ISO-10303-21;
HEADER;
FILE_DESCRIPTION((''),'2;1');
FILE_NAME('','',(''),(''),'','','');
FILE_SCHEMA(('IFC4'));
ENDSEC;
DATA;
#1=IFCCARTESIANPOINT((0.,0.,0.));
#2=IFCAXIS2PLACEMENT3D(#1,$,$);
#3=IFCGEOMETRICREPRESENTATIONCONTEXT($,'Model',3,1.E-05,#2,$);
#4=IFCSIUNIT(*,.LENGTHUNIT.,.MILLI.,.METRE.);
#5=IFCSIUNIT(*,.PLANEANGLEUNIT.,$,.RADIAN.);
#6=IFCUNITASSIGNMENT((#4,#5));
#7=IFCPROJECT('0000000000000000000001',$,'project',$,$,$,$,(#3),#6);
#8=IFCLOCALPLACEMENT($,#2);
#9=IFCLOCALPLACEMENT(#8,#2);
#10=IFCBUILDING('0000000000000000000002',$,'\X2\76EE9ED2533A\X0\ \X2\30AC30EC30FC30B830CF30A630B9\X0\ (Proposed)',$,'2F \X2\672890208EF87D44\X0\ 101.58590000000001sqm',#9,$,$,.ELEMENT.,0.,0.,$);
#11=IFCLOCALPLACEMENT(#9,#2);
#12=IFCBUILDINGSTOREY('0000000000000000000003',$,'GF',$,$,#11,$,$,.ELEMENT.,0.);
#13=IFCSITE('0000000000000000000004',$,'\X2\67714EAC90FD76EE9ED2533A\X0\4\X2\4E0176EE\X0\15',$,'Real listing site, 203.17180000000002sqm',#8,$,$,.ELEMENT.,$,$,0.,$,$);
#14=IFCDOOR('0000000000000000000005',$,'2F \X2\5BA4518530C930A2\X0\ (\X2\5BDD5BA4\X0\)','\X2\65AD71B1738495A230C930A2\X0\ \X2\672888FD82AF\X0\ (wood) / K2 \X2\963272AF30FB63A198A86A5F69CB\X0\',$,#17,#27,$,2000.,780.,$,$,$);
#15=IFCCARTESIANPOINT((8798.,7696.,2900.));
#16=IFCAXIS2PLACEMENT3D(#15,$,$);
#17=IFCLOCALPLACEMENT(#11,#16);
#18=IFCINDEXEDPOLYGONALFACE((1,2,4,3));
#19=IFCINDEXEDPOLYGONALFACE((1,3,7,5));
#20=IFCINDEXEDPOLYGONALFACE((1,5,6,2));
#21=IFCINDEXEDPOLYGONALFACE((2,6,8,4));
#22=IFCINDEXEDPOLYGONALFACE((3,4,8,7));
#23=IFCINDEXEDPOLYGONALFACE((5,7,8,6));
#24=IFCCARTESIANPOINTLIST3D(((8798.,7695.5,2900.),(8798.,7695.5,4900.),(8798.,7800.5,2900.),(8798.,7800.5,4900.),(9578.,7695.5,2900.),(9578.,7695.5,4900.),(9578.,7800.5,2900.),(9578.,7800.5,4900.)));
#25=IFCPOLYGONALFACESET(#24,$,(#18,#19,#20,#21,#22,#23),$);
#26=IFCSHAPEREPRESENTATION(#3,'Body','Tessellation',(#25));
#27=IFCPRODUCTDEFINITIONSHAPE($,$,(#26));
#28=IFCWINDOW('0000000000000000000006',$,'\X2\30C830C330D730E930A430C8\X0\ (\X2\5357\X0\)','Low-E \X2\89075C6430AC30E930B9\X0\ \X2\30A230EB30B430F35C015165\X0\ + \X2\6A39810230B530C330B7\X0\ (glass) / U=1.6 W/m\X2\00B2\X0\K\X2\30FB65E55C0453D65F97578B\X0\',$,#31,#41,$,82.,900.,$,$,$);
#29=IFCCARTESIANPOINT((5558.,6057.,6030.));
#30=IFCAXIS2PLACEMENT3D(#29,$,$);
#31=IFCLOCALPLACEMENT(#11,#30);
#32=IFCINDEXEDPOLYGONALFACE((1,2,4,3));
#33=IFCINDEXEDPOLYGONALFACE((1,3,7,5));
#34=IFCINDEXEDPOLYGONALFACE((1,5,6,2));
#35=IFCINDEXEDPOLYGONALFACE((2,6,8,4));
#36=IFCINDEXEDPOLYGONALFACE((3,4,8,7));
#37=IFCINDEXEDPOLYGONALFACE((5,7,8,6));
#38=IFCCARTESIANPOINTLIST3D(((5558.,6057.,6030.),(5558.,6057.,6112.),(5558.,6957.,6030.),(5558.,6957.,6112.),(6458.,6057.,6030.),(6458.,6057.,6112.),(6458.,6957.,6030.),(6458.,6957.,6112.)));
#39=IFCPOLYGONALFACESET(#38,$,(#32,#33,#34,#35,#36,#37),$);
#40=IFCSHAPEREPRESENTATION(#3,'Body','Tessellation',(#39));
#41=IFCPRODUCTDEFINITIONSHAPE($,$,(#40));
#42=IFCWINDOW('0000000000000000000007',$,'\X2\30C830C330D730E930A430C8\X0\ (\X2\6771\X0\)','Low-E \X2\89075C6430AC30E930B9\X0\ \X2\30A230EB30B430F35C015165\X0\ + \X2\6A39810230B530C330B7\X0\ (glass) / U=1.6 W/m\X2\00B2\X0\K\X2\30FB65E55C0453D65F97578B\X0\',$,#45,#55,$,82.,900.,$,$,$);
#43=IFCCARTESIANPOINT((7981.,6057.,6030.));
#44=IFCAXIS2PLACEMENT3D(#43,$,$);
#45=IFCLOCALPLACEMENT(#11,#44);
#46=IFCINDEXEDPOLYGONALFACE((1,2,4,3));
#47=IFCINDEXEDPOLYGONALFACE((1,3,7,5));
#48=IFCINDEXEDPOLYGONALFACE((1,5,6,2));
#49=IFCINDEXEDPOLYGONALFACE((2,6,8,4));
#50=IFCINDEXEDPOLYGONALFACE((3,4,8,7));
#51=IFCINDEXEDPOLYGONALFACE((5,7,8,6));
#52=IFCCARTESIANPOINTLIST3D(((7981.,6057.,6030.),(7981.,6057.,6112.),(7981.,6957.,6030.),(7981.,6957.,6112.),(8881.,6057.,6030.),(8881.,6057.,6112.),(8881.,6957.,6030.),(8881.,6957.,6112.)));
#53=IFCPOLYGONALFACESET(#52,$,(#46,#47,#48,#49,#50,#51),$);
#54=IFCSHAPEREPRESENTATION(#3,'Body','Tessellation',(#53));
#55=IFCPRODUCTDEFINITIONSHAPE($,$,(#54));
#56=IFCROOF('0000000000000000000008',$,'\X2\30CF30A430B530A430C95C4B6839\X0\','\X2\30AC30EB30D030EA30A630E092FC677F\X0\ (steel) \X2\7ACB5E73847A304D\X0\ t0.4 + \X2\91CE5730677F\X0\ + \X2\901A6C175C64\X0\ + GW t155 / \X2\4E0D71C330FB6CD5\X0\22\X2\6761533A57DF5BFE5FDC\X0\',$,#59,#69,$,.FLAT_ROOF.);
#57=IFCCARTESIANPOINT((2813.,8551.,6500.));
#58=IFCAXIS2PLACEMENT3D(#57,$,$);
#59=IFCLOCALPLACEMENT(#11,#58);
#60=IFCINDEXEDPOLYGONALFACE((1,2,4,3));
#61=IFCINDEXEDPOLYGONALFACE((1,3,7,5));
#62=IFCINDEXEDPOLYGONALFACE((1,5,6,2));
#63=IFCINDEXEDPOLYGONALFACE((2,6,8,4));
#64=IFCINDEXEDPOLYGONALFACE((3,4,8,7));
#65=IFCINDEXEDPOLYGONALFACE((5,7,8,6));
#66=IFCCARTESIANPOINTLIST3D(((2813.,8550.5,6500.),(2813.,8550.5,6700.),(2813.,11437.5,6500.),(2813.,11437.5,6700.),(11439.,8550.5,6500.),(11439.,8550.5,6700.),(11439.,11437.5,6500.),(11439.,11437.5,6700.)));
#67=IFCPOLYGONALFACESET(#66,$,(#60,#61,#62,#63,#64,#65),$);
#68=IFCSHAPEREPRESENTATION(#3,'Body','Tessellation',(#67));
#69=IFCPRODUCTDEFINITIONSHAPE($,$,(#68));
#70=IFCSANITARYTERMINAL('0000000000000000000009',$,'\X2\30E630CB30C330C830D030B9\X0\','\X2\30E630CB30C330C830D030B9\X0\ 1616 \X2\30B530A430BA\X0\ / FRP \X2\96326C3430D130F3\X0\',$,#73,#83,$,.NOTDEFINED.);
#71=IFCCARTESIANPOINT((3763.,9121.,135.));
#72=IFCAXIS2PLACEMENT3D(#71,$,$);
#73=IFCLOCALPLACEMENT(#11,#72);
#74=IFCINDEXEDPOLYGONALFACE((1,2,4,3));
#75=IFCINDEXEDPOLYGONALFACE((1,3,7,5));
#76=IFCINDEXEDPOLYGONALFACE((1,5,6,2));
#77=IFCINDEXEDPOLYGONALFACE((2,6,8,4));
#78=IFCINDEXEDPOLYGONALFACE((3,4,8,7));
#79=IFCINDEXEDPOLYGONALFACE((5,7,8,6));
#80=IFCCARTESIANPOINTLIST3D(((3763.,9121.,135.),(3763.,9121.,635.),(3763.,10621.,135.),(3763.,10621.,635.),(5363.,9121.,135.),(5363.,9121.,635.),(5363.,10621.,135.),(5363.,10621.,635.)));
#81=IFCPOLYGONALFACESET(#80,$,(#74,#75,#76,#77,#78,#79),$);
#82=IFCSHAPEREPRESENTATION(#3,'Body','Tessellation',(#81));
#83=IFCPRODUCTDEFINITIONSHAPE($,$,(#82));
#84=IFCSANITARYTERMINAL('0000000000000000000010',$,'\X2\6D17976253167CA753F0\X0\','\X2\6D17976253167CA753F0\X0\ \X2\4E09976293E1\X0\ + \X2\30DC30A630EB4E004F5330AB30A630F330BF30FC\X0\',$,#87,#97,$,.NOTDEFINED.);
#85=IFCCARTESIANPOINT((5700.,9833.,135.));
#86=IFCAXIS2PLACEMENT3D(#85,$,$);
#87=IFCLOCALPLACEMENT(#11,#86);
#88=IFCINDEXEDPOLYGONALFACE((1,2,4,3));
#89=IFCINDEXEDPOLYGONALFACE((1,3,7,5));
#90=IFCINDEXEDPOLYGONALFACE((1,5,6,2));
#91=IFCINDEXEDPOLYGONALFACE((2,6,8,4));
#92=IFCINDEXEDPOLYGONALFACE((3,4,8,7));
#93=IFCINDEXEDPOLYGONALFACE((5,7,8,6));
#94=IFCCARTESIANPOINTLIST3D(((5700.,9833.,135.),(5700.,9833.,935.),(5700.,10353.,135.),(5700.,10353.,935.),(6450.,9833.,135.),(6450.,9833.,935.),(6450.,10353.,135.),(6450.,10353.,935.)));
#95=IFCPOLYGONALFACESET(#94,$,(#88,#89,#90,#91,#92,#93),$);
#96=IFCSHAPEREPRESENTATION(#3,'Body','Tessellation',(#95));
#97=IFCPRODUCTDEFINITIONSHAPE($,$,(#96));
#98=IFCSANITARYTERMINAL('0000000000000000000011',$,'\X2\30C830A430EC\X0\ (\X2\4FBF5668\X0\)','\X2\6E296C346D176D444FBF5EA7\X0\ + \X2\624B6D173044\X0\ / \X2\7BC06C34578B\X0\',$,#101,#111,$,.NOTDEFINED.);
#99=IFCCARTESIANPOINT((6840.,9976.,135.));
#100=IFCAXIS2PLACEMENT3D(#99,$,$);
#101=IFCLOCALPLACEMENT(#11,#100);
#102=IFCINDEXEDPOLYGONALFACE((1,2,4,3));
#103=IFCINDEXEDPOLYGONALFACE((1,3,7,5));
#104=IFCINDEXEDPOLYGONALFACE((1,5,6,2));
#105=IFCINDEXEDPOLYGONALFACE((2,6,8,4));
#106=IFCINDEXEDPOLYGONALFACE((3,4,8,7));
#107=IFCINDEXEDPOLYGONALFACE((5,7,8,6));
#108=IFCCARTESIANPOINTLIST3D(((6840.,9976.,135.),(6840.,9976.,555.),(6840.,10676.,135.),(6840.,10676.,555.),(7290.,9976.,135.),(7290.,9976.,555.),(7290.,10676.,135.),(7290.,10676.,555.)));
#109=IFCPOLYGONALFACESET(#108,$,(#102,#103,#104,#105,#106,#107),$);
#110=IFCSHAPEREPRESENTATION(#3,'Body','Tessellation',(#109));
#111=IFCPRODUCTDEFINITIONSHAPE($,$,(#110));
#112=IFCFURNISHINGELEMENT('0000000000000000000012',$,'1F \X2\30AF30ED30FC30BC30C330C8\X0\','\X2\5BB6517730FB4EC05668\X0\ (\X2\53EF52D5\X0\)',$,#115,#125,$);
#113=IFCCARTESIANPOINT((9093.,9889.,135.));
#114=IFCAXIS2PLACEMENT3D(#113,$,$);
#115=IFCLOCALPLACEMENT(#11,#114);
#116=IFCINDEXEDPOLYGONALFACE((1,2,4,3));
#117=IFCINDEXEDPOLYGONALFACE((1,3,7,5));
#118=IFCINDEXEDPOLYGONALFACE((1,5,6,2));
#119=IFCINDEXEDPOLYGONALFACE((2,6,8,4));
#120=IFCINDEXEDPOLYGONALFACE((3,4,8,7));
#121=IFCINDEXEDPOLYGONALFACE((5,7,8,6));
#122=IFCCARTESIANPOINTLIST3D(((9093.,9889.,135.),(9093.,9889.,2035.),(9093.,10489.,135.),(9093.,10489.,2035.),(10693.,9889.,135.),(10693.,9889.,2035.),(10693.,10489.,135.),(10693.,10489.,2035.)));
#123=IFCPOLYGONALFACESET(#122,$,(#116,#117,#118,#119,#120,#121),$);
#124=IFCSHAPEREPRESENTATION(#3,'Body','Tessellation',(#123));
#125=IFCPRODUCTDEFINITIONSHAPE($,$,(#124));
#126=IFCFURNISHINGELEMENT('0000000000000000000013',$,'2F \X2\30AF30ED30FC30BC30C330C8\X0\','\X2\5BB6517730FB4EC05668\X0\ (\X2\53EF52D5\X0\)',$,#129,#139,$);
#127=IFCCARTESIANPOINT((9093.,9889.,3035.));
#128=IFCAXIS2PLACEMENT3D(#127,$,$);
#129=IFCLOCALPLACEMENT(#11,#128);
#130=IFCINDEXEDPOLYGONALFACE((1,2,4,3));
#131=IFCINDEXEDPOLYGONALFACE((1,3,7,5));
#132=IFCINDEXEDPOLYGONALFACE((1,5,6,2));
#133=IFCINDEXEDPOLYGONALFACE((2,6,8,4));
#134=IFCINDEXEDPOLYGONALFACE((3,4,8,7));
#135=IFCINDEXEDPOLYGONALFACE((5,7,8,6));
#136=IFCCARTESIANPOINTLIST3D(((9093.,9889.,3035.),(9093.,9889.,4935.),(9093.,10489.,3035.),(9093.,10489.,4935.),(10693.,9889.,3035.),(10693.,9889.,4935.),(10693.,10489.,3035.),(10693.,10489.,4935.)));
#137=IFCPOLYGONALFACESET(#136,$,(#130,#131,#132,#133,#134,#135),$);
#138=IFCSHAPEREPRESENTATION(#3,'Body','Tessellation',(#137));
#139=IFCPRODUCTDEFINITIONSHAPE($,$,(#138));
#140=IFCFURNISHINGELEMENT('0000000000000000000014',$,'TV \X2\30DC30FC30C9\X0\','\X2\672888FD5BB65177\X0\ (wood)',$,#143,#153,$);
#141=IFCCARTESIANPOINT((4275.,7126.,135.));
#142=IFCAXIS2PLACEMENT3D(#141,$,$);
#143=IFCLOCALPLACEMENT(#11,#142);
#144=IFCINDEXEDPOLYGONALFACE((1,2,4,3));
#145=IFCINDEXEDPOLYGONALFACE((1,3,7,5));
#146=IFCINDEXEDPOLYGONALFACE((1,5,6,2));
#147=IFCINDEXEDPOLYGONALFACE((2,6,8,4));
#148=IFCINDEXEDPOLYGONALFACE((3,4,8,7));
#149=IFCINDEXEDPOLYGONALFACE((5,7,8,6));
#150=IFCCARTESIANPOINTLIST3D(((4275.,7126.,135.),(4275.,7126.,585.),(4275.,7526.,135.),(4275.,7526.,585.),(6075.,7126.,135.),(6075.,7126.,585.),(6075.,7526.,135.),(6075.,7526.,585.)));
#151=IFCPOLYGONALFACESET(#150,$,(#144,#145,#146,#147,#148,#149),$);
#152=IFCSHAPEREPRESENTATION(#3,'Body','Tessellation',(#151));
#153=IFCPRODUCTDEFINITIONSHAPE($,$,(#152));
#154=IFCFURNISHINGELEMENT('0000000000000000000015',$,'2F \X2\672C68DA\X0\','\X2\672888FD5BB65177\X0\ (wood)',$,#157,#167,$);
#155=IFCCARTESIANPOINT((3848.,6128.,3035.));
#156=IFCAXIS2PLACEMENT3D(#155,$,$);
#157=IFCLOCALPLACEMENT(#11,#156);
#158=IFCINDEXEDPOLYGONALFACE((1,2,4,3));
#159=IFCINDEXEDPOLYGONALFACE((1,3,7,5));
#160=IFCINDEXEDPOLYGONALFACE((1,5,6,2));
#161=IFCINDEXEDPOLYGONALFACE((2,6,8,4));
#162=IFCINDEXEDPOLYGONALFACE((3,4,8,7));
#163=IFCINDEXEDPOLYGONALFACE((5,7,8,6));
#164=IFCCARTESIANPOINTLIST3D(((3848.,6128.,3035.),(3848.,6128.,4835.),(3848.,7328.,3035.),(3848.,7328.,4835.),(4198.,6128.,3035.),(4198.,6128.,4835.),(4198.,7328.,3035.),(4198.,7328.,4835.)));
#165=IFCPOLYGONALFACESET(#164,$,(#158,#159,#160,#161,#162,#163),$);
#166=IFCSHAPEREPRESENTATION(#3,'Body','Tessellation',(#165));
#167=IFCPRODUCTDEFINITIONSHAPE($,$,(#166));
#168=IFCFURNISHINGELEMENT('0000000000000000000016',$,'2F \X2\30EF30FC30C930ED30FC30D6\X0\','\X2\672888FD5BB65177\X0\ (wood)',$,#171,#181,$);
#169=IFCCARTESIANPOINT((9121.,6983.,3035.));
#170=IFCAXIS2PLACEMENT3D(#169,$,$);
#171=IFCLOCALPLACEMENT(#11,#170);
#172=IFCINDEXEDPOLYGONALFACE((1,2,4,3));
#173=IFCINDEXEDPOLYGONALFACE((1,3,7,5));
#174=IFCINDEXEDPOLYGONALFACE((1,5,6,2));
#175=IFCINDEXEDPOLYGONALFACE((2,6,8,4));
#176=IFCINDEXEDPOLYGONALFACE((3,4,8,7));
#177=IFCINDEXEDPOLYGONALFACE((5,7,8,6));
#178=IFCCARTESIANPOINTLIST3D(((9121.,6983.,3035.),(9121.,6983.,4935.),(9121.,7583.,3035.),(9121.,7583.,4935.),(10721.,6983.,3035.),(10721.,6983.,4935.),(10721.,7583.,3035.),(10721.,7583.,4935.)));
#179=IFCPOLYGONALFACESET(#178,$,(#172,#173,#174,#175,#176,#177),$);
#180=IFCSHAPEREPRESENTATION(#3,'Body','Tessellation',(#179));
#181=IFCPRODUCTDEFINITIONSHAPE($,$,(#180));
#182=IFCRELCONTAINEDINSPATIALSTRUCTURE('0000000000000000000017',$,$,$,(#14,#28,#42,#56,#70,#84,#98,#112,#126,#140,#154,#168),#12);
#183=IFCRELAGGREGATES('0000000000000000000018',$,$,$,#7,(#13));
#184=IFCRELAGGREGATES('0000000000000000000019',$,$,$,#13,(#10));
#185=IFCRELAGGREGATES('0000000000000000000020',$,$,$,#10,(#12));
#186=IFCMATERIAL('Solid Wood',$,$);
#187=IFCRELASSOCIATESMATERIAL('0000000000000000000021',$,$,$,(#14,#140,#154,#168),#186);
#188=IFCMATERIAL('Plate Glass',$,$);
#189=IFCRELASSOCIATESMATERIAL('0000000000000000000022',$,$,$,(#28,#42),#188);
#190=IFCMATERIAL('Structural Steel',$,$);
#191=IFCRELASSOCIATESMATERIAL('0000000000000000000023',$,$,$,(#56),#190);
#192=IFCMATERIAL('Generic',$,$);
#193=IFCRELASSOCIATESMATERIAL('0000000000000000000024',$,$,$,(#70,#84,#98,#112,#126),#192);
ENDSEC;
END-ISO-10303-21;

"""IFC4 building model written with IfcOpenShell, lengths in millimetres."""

from ifc_helpers import new_model, si_unit, frame, frame_2d, origin, place, context, project, spatial, rectangle, extrude, material, element, save


model = new_model("IFC4")

# Units and contexts
model_context = context("Model", 3, precision=1e-05, world=origin())
ifc_project = project(units=[si_unit("LENGTHUNIT", "METRE", prefix="MILLI"), si_unit("PLANEANGLEUNIT", "RADIAN")], contexts=[model_context])

# Site, building, storey
site_placement = place(None, origin())
site = spatial("IfcSite", under=ifc_project, at=site_placement, Name="東京都目黒区4丁目15", ObjectType="Real listing site, 203.17180000000002sqm", CompositionType="ELEMENT", RefElevation=0.0)
building_placement = place(site_placement, origin())
building = spatial("IfcBuilding", under=site, at=building_placement, Name="目黒区 ガレージハウス (Proposed)", ObjectType="2F 木造軸組 101.58590000000001sqm", CompositionType="ELEMENT", ElevationOfRefHeight=0.0, ElevationOfTerrain=0.0)
storey_placement = place(building_placement, origin())
storey = spatial("IfcBuildingStorey", under=building, at=storey_placement, Name="GF", CompositionType="ELEMENT", Elevation=0.0)

# Shared definitions
ifc_material_1 = material(Name="Solid Wood")
ifc_material_2 = material(Name="Plate Glass")

# Door
door_1_placement = place(storey_placement, frame((8798.0, 7696.0, 2900.0)))
element("IfcDoor", 1, at=door_1_placement, inside=storey, material=ifc_material_1, Name="2F 室内ドア (寝室)", Description="断熱玄関ドア 木製芯 (wood) / K2 防犯・採風機構", OverallHeight=2000.0, OverallWidth=780.0, context=model_context, shape_type="SweptSolid", body=[
    extrude(rectangle(XDim=780.0, YDim=105.0, at=frame_2d((390.0, 52.0))), frame((8798.0, 7696.0, 2900.0)), (0.0, 0.0, 1.0), 2000.0),
])

# Windows
window_1_placement = place(storey_placement, frame((5558.0, 6057.0, 6030.0)))
element("IfcWindow", 2, at=window_1_placement, inside=storey, material=ifc_material_2, Name="トップライト (南)", Description="Low-E 複層ガラス アルゴン封入 + 樹脂サッシ (glass) / U=1.6 W/m²K・日射取得型", OverallHeight=82.0, OverallWidth=900.0, context=model_context, shape_type="SweptSolid", body=[
    extrude(rectangle(XDim=900.0, YDim=900.0, at=frame_2d((450.0, 450.0))), frame((5558.0, 6057.0, 6030.0)), (0.0, 0.0, 1.0), 82.0),
])
window_2_placement = place(storey_placement, frame((7981.0, 6057.0, 6030.0)))
element("IfcWindow", 3, at=window_2_placement, inside=storey, material=ifc_material_2, Name="トップライト (東)", Description="Low-E 複層ガラス アルゴン封入 + 樹脂サッシ (glass) / U=1.6 W/m²K・日射取得型", OverallHeight=82.0, OverallWidth=900.0, context=model_context, shape_type="SweptSolid", body=[
    extrude(rectangle(XDim=900.0, YDim=900.0, at=frame_2d((450.0, 450.0))), frame((7981.0, 6057.0, 6030.0)), (0.0, 0.0, 1.0), 82.0),
])

# Roof
ifc_material_3 = material(Name="Structural Steel")
roof_placement = place(storey_placement, frame((2813.0, 8551.0, 6500.0)))
element("IfcRoof", 4, at=roof_placement, inside=storey, material=ifc_material_3, Name="ハイサイド屋根", Description="ガルバリウム鋼板 (steel) 立平葺き t0.4 + 野地板 + 通気層 + GW t155 / 不燃・法22条区域対応", PredefinedType="FLAT_ROOF", context=model_context, shape_type="SweptSolid", body=[
    extrude(rectangle(XDim=8626.0, YDim=2887.0, at=frame_2d((4313.0, 1443.0))), frame((2813.0, 8551.0, 6500.0)), (0.0, 0.0, 1.0), 200.0),
])

# Sanitary terminals
ifc_material_4 = material(Name="Generic")
sanitary_terminal_1_placement = place(storey_placement, frame((3763.0, 9121.0, 135.0)))
element("IfcSanitaryTerminal", 5, at=sanitary_terminal_1_placement, inside=storey, material=ifc_material_4, Name="ユニットバス", Description="ユニットバス 1616 サイズ / FRP 防水パン", PredefinedType="NOTDEFINED", context=model_context, shape_type="SweptSolid", body=[
    extrude(rectangle(XDim=1600.0, YDim=1500.0, at=frame_2d((800.0, 750.0))), frame((3763.0, 9121.0, 135.0)), (0.0, 0.0, 1.0), 500.0),
])
sanitary_terminal_2_placement = place(storey_placement, frame((5700.0, 9833.0, 135.0)))
element("IfcSanitaryTerminal", 6, at=sanitary_terminal_2_placement, inside=storey, material=ifc_material_4, Name="洗面化粧台", Description="洗面化粧台 三面鏡 + ボウル一体カウンター", PredefinedType="NOTDEFINED", context=model_context, shape_type="SweptSolid", body=[
    extrude(rectangle(XDim=750.0, YDim=520.0, at=frame_2d((375.0, 260.0))), frame((5700.0, 9833.0, 135.0)), (0.0, 0.0, 1.0), 800.0),
])
sanitary_terminal_3_placement = place(storey_placement, frame((6840.0, 9976.0, 135.0)))
element("IfcSanitaryTerminal", 7, at=sanitary_terminal_3_placement, inside=storey, material=ifc_material_4, Name="トイレ (便器)", Description="温水洗浄便座 + 手洗い / 節水型", PredefinedType="NOTDEFINED", context=model_context, shape_type="SweptSolid", body=[
    extrude(rectangle(XDim=450.0, YDim=700.0, at=frame_2d((225.0, 350.0))), frame((6840.0, 9976.0, 135.0)), (0.0, 0.0, 1.0), 420.0),
])

# Furnishing elements
furnishing_1_placement = place(storey_placement, frame((9093.0, 9889.0, 135.0)))
element("IfcFurnishingElement", 8, at=furnishing_1_placement, inside=storey, material=ifc_material_4, Name="1F クローゼット", Description="家具・什器 (可動)", context=model_context, shape_type="SweptSolid", body=[
    extrude(rectangle(XDim=1600.0, YDim=600.0, at=frame_2d((800.0, 300.0))), frame((9093.0, 9889.0, 135.0)), (0.0, 0.0, 1.0), 1900.0),
])
furnishing_2_placement = place(storey_placement, frame((9093.0, 9889.0, 3035.0)))
element("IfcFurnishingElement", 9, at=furnishing_2_placement, inside=storey, material=ifc_material_4, Name="2F クローゼット", Description="家具・什器 (可動)", context=model_context, shape_type="SweptSolid", body=[
    extrude(rectangle(XDim=1600.0, YDim=600.0, at=frame_2d((800.0, 300.0))), frame((9093.0, 9889.0, 3035.0)), (0.0, 0.0, 1.0), 1900.0),
])
furnishing_3_placement = place(storey_placement, frame((4275.0, 7126.0, 135.0)))
element("IfcFurnishingElement", 10, at=furnishing_3_placement, inside=storey, material=ifc_material_1, Name="TV ボード", Description="木製家具 (wood)", context=model_context, shape_type="SweptSolid", body=[
    extrude(rectangle(XDim=1800.0, YDim=400.0, at=frame_2d((900.0, 200.0))), frame((4275.0, 7126.0, 135.0)), (0.0, 0.0, 1.0), 450.0),
])
furnishing_4_placement = place(storey_placement, frame((3848.0, 6128.0, 3035.0)))
element("IfcFurnishingElement", 11, at=furnishing_4_placement, inside=storey, material=ifc_material_1, Name="2F 本棚", Description="木製家具 (wood)", context=model_context, shape_type="SweptSolid", body=[
    extrude(rectangle(XDim=350.0, YDim=1200.0, at=frame_2d((175.0, 600.0))), frame((3848.0, 6128.0, 3035.0)), (0.0, 0.0, 1.0), 1800.0),
])
furnishing_5_placement = place(storey_placement, frame((9121.0, 6983.0, 3035.0)))
element("IfcFurnishingElement", 12, at=furnishing_5_placement, inside=storey, material=ifc_material_1, Name="2F ワードローブ", Description="木製家具 (wood)", context=model_context, shape_type="SweptSolid", body=[
    extrude(rectangle(XDim=1600.0, YDim=600.0, at=frame_2d((800.0, 300.0))), frame((9121.0, 6983.0, 3035.0)), (0.0, 0.0, 1.0), 1900.0),
])

save(model, "model.ifc")
